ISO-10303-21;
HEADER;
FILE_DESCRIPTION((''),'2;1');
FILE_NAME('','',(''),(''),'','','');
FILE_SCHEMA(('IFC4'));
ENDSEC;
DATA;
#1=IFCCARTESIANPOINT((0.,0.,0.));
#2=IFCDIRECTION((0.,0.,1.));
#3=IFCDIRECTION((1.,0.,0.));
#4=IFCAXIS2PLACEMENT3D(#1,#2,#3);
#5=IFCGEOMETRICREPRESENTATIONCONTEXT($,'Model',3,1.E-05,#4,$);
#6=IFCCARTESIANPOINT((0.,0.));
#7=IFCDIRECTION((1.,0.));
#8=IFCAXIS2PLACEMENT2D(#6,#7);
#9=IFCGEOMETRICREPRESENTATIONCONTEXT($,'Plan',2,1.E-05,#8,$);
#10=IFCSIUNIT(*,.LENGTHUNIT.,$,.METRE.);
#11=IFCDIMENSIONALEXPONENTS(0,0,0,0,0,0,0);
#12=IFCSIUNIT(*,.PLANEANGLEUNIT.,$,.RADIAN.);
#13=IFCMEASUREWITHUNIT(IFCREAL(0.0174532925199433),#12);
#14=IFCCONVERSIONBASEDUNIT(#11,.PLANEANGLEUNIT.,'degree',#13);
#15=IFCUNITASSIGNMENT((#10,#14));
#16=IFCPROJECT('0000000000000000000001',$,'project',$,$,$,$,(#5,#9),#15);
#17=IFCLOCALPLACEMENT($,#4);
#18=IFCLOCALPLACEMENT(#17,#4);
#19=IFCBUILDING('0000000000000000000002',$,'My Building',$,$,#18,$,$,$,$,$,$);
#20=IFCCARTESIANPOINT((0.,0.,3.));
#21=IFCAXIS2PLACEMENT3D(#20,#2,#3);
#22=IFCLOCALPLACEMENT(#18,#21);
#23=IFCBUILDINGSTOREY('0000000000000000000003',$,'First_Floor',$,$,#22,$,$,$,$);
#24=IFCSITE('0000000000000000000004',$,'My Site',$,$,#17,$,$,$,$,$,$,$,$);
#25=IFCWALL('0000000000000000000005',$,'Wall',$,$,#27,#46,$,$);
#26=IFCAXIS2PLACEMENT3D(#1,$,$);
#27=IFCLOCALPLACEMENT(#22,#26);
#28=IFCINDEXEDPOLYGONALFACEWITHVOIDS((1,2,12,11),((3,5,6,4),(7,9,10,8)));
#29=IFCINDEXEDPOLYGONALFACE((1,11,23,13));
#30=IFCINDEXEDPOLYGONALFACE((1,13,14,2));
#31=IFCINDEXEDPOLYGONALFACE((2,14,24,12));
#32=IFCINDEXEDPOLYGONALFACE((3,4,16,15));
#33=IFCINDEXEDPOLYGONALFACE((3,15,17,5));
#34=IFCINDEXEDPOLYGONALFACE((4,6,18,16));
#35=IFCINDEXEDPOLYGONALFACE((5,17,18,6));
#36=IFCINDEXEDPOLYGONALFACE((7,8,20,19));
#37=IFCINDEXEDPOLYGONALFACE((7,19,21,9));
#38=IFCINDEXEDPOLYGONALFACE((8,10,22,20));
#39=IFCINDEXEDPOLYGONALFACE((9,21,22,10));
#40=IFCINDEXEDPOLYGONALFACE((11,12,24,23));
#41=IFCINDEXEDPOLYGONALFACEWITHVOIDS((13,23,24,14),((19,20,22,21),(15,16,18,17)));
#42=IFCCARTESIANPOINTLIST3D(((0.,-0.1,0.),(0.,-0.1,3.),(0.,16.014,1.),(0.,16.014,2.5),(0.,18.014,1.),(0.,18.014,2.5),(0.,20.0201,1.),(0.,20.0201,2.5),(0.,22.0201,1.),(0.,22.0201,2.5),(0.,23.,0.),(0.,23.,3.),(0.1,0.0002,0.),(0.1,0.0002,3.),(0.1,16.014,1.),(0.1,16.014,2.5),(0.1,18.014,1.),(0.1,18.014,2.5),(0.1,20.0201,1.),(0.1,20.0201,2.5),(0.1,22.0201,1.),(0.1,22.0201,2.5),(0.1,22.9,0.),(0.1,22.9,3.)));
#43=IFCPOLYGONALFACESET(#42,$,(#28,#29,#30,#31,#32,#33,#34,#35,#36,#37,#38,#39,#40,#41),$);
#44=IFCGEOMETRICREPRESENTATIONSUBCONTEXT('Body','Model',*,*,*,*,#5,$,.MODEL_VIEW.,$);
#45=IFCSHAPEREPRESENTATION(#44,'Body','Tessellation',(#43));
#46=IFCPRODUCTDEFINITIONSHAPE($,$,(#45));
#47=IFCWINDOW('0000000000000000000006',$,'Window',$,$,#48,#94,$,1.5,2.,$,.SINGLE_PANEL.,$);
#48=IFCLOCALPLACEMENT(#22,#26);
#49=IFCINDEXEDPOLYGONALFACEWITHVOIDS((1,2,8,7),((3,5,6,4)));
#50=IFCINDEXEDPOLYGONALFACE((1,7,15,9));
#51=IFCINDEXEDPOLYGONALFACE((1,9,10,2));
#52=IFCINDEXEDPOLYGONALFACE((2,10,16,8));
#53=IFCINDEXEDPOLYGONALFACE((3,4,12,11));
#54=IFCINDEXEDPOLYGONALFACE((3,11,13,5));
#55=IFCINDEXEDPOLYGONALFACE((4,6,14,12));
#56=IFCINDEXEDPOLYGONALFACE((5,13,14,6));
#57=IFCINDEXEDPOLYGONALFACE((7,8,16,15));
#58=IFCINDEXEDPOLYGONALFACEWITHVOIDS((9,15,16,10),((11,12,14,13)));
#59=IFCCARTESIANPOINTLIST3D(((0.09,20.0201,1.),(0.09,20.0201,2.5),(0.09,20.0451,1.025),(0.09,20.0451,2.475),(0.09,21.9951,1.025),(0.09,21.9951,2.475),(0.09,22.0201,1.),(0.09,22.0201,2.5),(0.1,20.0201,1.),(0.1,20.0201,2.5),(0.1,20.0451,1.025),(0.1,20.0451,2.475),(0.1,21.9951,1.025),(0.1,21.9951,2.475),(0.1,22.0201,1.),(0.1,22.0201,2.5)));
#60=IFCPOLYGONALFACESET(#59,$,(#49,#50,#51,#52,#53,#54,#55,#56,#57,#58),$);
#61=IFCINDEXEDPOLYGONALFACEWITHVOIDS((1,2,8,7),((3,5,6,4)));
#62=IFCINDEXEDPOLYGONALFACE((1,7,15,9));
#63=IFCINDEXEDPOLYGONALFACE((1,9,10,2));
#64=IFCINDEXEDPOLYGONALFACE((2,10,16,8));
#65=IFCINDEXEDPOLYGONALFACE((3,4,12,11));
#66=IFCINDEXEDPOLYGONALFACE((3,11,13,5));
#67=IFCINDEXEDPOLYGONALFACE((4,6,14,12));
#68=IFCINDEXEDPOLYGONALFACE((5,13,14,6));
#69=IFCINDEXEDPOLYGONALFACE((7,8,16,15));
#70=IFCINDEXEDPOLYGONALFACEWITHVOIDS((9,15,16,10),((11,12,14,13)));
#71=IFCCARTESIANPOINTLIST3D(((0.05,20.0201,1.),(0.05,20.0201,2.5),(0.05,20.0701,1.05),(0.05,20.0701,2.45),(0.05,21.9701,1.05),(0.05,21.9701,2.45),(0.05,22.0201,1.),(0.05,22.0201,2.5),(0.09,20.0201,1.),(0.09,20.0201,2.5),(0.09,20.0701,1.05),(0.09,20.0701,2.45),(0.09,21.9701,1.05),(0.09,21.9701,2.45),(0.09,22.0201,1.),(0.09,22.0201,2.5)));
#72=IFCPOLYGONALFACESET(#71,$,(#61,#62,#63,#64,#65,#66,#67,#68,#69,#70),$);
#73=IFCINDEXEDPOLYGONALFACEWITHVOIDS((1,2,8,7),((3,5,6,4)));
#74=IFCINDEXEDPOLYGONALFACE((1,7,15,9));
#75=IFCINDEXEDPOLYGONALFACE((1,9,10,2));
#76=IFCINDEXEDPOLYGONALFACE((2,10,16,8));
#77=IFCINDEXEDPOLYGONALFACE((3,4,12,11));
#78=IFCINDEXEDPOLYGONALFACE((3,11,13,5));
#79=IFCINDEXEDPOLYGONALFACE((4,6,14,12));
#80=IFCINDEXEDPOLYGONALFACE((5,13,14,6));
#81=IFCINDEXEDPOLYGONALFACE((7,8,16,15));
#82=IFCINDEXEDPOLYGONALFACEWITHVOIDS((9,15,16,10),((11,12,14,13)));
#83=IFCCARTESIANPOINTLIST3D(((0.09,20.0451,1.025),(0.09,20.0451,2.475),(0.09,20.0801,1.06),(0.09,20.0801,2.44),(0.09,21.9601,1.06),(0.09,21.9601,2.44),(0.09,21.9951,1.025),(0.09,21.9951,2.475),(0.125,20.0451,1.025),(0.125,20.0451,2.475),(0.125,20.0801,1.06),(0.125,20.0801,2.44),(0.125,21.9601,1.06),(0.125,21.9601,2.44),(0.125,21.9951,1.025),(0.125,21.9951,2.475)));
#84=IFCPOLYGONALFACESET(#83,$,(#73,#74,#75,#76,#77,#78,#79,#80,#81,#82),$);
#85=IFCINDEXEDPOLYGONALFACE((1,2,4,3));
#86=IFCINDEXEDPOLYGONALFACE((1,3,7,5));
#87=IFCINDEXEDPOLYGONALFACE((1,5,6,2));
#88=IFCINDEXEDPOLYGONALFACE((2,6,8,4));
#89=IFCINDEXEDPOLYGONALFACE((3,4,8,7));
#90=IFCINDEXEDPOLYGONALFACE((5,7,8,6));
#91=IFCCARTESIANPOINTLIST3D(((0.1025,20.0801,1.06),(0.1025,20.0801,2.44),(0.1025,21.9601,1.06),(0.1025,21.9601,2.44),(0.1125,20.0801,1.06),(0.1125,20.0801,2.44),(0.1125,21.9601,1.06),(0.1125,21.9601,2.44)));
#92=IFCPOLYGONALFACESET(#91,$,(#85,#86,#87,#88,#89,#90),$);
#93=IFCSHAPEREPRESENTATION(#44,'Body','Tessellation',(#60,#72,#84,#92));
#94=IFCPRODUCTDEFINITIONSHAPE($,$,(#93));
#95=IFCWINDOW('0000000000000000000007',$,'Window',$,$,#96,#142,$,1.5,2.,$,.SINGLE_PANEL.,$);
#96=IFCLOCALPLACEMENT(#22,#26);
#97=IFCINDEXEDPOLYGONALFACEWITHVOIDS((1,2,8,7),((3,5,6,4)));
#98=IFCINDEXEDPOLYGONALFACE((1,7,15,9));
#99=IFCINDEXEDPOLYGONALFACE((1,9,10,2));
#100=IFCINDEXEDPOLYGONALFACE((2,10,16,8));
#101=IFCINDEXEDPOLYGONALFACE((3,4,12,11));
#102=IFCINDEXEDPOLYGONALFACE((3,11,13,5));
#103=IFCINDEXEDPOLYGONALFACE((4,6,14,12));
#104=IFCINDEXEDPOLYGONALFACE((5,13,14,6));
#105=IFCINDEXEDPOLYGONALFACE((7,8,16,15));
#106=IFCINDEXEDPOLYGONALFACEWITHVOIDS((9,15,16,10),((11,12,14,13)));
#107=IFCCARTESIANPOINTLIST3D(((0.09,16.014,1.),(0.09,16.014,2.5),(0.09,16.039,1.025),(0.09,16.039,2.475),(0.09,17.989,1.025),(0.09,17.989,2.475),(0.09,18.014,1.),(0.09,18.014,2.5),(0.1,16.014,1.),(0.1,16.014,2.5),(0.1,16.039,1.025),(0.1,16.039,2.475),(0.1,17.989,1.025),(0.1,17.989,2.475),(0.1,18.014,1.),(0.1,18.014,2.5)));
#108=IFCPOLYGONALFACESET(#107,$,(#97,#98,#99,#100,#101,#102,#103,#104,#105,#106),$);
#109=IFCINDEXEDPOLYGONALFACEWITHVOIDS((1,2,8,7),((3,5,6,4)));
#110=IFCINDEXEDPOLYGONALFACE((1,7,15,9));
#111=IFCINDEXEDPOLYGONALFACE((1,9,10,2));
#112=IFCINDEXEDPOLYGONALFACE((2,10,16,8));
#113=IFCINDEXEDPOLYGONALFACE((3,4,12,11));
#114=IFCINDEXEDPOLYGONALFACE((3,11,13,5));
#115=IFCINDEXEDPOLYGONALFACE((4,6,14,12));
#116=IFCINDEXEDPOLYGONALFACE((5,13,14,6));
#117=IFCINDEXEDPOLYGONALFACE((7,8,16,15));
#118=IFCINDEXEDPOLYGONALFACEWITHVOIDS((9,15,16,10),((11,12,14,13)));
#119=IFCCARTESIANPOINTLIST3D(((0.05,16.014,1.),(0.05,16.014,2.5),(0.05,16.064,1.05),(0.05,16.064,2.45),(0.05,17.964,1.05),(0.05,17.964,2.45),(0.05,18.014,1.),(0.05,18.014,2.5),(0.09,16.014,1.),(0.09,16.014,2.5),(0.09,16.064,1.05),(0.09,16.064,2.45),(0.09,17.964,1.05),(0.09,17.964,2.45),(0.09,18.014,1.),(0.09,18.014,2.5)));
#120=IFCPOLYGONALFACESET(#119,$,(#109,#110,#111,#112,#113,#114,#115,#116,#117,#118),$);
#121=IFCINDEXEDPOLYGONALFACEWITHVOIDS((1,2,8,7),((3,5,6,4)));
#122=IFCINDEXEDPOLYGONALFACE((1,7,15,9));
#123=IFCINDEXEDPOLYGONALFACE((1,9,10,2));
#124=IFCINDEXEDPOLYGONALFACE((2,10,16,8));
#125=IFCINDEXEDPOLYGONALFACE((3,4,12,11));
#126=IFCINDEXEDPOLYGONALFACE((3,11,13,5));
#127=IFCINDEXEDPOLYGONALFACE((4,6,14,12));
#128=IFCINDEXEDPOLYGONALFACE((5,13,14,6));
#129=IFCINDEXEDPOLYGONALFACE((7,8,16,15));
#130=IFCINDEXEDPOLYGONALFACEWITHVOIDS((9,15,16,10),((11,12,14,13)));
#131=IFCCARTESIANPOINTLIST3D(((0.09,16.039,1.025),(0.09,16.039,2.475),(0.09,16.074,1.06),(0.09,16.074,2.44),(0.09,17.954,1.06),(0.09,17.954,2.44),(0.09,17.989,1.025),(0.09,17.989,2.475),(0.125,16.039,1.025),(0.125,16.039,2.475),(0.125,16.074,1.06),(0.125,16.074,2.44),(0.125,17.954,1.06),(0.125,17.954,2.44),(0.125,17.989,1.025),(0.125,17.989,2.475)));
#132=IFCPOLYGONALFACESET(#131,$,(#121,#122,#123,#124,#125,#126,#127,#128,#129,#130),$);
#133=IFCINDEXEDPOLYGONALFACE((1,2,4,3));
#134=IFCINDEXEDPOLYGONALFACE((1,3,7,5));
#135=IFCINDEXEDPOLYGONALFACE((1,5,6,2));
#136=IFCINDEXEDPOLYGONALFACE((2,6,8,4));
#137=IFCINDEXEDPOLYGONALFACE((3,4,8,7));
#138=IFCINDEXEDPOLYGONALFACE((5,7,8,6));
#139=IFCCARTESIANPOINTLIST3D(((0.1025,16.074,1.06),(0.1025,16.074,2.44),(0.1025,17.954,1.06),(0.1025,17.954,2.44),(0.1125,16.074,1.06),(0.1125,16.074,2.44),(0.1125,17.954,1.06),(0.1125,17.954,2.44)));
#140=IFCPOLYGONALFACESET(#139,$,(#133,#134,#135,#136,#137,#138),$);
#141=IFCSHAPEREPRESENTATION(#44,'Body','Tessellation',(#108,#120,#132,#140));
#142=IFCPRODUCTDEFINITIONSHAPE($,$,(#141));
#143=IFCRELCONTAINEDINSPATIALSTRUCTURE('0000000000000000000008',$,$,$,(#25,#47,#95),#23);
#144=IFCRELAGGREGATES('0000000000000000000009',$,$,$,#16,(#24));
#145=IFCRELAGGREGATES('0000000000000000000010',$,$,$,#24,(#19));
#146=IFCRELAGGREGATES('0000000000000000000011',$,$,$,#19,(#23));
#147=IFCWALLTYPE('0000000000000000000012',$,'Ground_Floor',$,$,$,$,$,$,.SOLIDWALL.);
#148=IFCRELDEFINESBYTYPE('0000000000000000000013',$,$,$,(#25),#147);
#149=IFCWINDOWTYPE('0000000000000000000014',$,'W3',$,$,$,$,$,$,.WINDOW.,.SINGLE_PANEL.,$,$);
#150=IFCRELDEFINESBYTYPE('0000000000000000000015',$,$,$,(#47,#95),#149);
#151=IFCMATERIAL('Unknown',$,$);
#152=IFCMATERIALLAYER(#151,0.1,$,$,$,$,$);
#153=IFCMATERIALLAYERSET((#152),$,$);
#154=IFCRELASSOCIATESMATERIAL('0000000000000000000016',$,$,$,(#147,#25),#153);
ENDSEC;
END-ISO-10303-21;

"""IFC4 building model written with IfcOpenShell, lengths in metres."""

from ifc_helpers import new_model, entity, si_unit, converted_unit, frame, origin_with_axes, origin_2d_with_axis, place, context, subcontext, project, spatial, line, indexed_curve, outline, extrude, shape, source, transform, mapped, material, layer, layer_set, layer_usage, type_object, type_shapes, element, fill, save


model = new_model("IFC4")

# Units and contexts
model_context = context("Model", 3, precision=1e-05, world=origin_with_axes())
plan_context = context("Plan", 2, precision=1e-05, world=origin_2d_with_axis())
body_context_1 = subcontext(model_context, "Body", "Model", "MODEL_VIEW")
body_context_2 = subcontext(plan_context, "Body", "Plan", "PLAN_VIEW")
ifc_project = project(units=[si_unit("LENGTHUNIT", "METRE"), converted_unit("PLANEANGLEUNIT", "degree", entity("IfcReal", 0.0174532925199433), si_unit("PLANEANGLEUNIT", "RADIAN"), dimensions=[0, 0, 0, 0, 0, 0, 0])], contexts=[model_context, plan_context])

# Site, building, storey
site_placement = place(None, origin_with_axes())
site = spatial("IfcSite", under=ifc_project, at=site_placement, Name="My Site")
building_placement = place(site_placement, origin_with_axes())
building = spatial("IfcBuilding", under=site, at=building_placement, Name="My Building")
storey_placement = place(building_placement, frame((0.0, 0.0, 3.0), z_axis=(0.0, 0.0, 1.0), x_axis=(1.0, 0.0, 0.0)))
storey = spatial("IfcBuildingStorey", under=building, at=storey_placement, Name="First_Floor")

# Shared definitions
ifc_material = material(Name="Unknown")

# Shared definitions
ifc_layer = layer(ifc_material, 0.1)
ifc_layer_set = layer_set([ifc_layer])
wall_type = type_object("IfcWallType", Name="Ground_Floor", PredefinedType="SOLIDWALL", material=ifc_layer_set)

# Wall, openings, windows
ifc_layer_usage_1 = layer_usage(ifc_layer_set, "AXIS2", "POSITIVE", 0.0)
wall_1_placement = place(storey_placement, frame((0.1, 0.0002, 0.0), z_axis=(0.0, 0.0, 1.0), x_axis=(0.0, 1.0, 0.0)))
wall_1 = element("IfcWall", 1, at=wall_1_placement, inside=storey, type_object=wall_type, material=ifc_layer_usage_1, Name="Wall", context=body_context_1, shape_type="SweptSolid", body=[
    extrude(outline(indexed_curve([(0.0, 0.0), (-0.1002, 0.1), (22.9998, 0.1), (22.8998, 0.0)], segments=[line(1, 2, 3, 4, 1)])), origin_with_axes(), (0.0, 0.0, 1.0), 3.0),
])
shared_shape_1 = source(origin_with_axes(), body_context_1, "Body", "SweptSolid", [
    extrude(outline(indexed_curve([(0.0, 0.0), (2.0, 0.0), (2.0, 1.5), (0.0, 1.5)], segments=[line(1, 2, 3, 4, 1)])), frame((0.0, -0.6, 0.0), z_axis=(0.0, -1.0, 0.0), x_axis=(1.0, 0.0, 0.0)), (0.0, 0.0, -1.0), 1.2),
])
opening_1_placement = place(wall_1_placement, frame((22.0199, 0.1, 1.0), z_axis=(0.0, 0.0, 1.0), x_axis=(-1.0, 0.0, 0.0)))
opening_1 = element("IfcOpeningElement", 2, at=opening_1_placement, cuts=wall_1, PredefinedType="OPENING", context=body_context_1, shape_type="MappedRepresentation", body=[
    mapped(shared_shape_1, transform((0.0, 0.0, 0.0), x_axis=(1.0, 0.0, 0.0), y_axis=(0.0, 1.0, 0.0), z_axis=(0.0, 0.0, 1.0), scale=1.0)),
])
opening_2_placement = place(wall_1_placement, frame((18.0138, 0.1, 1.0), z_axis=(0.0, 0.0, 1.0), x_axis=(-1.0, 0.0, 0.0)))
opening_2 = element("IfcOpeningElement", 3, at=opening_2_placement, cuts=wall_1, PredefinedType="OPENING", context=body_context_1, shape_type="MappedRepresentation", body=[
    mapped(shared_shape_1, transform((0.0, 0.0, 0.0), x_axis=(1.0, 0.0, 0.0), y_axis=(0.0, 1.0, 0.0), z_axis=(0.0, 0.0, 1.0), scale=1.0)),
])
window_type = type_object("IfcWindowType", Name="W3", PartitioningType="SINGLE_PANEL", PredefinedType="WINDOW")
shared_shape_2 = source(origin_with_axes(), body_context_1, "Body", "SweptSolid", [
    extrude(outline(indexed_curve([(0.0, 0.0), (2.0, 0.0), (2.0, 1.5), (0.0, 1.5)], segments=[line(1, 2, 3, 4, 1)]), holes=[indexed_curve([(0.025, 0.025), (1.975, 0.025), (1.975, 1.475), (0.025, 1.475)], segments=[line(1, 2, 3, 4, 1)])]), frame((0.0, 0.09, 0.0), z_axis=(0.0, -1.0, 0.0), x_axis=(1.0, 0.0, 0.0)), (0.0, 0.0, -1.0), 0.01),
    extrude(outline(indexed_curve([(0.0, 0.0), (2.0, 0.0), (2.0, 1.5), (0.0, 1.5)], segments=[line(1, 2, 3, 4, 1)]), holes=[indexed_curve([(0.05, 0.05), (1.95, 0.05), (1.95, 1.45), (0.05, 1.45)], segments=[line(1, 2, 3, 4, 1)])]), frame((0.0, 0.05, 0.0), z_axis=(0.0, -1.0, 0.0), x_axis=(1.0, 0.0, 0.0)), (0.0, 0.0, -1.0), 0.04),
    extrude(outline(indexed_curve([(0.0, 0.0), (1.95, 0.0), (1.95, 1.45), (0.0, 1.45)], segments=[line(1, 2, 3, 4, 1)]), holes=[indexed_curve([(0.035, 0.035), (1.915, 0.035), (1.915, 1.415), (0.035, 1.415)], segments=[line(1, 2, 3, 4, 1)])]), frame((0.025, 0.09, 0.025), z_axis=(0.0, -1.0, 0.0), x_axis=(1.0, 0.0, 0.0)), (0.0, 0.0, -1.0), 0.035),
    extrude(outline(indexed_curve([(0.035, 0.035), (1.915, 0.035), (1.915, 1.415), (0.035, 1.415)], segments=[line(1, 2, 3, 4, 1)])), frame((0.025, 0.1025, 0.025), z_axis=(0.0, -1.0, 0.0), x_axis=(1.0, 0.0, 0.0)), (0.0, 0.0, -1.0), 0.01),
])
shared_shape_3 = source(origin_with_axes(), body_context_2, "Body", "Curve2D", [
    entity("IfcIndexedPolyCurve", entity("IfcCartesianPointList2D", [[0.05, 0.05], [1.95, 0.05]])),
    entity("IfcIndexedPolyCurve", entity("IfcCartesianPointList2D", [[0.0, 0.1], [0.025, 0.1], [0.025, 0.09], [0.05, 0.09], [0.05, 0.05], [0.0, 0.05]]), [entity("IfcLineIndex", [1, 2, 3, 4, 5, 6, 1])]),
    entity("IfcIndexedPolyCurve", entity("IfcCartesianPointList2D", [[2.0, 0.1], [1.975, 0.1], [1.975, 0.09], [1.95, 0.09], [1.95, 0.05], [2.0, 0.05]]), [entity("IfcLineIndex", [1, 2, 3, 4, 5, 6, 1])]),
    entity("IfcIndexedPolyCurve", entity("IfcCartesianPointList2D", [[0.025, 0.09], [0.06, 0.09], [0.06, 0.125], [0.025, 0.125]]), [entity("IfcLineIndex", [1, 2, 3, 4, 1])]),
    entity("IfcIndexedPolyCurve", entity("IfcCartesianPointList2D", [[1.975, 0.09], [1.94, 0.09], [1.94, 0.125], [1.975, 0.125]]), [entity("IfcLineIndex", [1, 2, 3, 4, 1])]),
    entity("IfcIndexedPolyCurve", entity("IfcCartesianPointList2D", [[0.06, 0.09], [1.94, 0.09]])),
    entity("IfcIndexedPolyCurve", entity("IfcCartesianPointList2D", [[0.06, 0.125], [1.94, 0.125]])),
    entity("IfcIndexedPolyCurve", entity("IfcCartesianPointList2D", [[0.06, 0.1075], [1.94, 0.1075]])),
])
type_shapes(window_type, [shared_shape_2, shared_shape_3])
window_1_placement = place(opening_1_placement, frame((0.0, 0.0, 0.0), z_axis=(0.0, 0.0, 1.0), x_axis=(1.0, 0.0, 0.0)))
window_1 = element("IfcWindow", 4, at=window_1_placement, inside=storey, type_object=window_type, Name="Window", OverallHeight=1.5, OverallWidth=2.0, PartitioningType="SINGLE_PANEL", shapes=[
    shape(body_context_1, "Body", "MappedRepresentation", [mapped(shared_shape_2, transform((0.0, 0.0, 0.0), x_axis=(1.0, 0.0, 0.0), y_axis=(0.0, 1.0, 0.0), z_axis=(0.0, 0.0, 1.0), scale=1.0))]),
    shape(body_context_2, "Body", "MappedRepresentation", [mapped(shared_shape_3, transform((0.0, 0.0, 0.0), x_axis=(1.0, 0.0, 0.0), y_axis=(0.0, 1.0, 0.0), z_axis=(0.0, 0.0, 1.0), scale=1.0))]),
])
fill(opening_1, window_1)
window_2_placement = place(opening_2_placement, frame((0.0, 0.0, 0.0), z_axis=(0.0, 0.0, 1.0), x_axis=(1.0, 0.0, 0.0)))
window_2 = element("IfcWindow", 5, at=window_2_placement, inside=storey, type_object=window_type, Name="Window", OverallHeight=1.5, OverallWidth=2.0, PartitioningType="SINGLE_PANEL", shapes=[
    shape(body_context_1, "Body", "MappedRepresentation", [mapped(shared_shape_2, transform((0.0, 0.0, 0.0), x_axis=(1.0, 0.0, 0.0), y_axis=(0.0, 1.0, 0.0), z_axis=(0.0, 0.0, 1.0), scale=1.0))]),
    shape(body_context_2, "Body", "MappedRepresentation", [mapped(shared_shape_3, transform((0.0, 0.0, 0.0), x_axis=(1.0, 0.0, 0.0), y_axis=(0.0, 1.0, 0.0), z_axis=(0.0, 0.0, 1.0), scale=1.0))]),
])
fill(opening_2, window_2)

save(model, "model.ifc")
